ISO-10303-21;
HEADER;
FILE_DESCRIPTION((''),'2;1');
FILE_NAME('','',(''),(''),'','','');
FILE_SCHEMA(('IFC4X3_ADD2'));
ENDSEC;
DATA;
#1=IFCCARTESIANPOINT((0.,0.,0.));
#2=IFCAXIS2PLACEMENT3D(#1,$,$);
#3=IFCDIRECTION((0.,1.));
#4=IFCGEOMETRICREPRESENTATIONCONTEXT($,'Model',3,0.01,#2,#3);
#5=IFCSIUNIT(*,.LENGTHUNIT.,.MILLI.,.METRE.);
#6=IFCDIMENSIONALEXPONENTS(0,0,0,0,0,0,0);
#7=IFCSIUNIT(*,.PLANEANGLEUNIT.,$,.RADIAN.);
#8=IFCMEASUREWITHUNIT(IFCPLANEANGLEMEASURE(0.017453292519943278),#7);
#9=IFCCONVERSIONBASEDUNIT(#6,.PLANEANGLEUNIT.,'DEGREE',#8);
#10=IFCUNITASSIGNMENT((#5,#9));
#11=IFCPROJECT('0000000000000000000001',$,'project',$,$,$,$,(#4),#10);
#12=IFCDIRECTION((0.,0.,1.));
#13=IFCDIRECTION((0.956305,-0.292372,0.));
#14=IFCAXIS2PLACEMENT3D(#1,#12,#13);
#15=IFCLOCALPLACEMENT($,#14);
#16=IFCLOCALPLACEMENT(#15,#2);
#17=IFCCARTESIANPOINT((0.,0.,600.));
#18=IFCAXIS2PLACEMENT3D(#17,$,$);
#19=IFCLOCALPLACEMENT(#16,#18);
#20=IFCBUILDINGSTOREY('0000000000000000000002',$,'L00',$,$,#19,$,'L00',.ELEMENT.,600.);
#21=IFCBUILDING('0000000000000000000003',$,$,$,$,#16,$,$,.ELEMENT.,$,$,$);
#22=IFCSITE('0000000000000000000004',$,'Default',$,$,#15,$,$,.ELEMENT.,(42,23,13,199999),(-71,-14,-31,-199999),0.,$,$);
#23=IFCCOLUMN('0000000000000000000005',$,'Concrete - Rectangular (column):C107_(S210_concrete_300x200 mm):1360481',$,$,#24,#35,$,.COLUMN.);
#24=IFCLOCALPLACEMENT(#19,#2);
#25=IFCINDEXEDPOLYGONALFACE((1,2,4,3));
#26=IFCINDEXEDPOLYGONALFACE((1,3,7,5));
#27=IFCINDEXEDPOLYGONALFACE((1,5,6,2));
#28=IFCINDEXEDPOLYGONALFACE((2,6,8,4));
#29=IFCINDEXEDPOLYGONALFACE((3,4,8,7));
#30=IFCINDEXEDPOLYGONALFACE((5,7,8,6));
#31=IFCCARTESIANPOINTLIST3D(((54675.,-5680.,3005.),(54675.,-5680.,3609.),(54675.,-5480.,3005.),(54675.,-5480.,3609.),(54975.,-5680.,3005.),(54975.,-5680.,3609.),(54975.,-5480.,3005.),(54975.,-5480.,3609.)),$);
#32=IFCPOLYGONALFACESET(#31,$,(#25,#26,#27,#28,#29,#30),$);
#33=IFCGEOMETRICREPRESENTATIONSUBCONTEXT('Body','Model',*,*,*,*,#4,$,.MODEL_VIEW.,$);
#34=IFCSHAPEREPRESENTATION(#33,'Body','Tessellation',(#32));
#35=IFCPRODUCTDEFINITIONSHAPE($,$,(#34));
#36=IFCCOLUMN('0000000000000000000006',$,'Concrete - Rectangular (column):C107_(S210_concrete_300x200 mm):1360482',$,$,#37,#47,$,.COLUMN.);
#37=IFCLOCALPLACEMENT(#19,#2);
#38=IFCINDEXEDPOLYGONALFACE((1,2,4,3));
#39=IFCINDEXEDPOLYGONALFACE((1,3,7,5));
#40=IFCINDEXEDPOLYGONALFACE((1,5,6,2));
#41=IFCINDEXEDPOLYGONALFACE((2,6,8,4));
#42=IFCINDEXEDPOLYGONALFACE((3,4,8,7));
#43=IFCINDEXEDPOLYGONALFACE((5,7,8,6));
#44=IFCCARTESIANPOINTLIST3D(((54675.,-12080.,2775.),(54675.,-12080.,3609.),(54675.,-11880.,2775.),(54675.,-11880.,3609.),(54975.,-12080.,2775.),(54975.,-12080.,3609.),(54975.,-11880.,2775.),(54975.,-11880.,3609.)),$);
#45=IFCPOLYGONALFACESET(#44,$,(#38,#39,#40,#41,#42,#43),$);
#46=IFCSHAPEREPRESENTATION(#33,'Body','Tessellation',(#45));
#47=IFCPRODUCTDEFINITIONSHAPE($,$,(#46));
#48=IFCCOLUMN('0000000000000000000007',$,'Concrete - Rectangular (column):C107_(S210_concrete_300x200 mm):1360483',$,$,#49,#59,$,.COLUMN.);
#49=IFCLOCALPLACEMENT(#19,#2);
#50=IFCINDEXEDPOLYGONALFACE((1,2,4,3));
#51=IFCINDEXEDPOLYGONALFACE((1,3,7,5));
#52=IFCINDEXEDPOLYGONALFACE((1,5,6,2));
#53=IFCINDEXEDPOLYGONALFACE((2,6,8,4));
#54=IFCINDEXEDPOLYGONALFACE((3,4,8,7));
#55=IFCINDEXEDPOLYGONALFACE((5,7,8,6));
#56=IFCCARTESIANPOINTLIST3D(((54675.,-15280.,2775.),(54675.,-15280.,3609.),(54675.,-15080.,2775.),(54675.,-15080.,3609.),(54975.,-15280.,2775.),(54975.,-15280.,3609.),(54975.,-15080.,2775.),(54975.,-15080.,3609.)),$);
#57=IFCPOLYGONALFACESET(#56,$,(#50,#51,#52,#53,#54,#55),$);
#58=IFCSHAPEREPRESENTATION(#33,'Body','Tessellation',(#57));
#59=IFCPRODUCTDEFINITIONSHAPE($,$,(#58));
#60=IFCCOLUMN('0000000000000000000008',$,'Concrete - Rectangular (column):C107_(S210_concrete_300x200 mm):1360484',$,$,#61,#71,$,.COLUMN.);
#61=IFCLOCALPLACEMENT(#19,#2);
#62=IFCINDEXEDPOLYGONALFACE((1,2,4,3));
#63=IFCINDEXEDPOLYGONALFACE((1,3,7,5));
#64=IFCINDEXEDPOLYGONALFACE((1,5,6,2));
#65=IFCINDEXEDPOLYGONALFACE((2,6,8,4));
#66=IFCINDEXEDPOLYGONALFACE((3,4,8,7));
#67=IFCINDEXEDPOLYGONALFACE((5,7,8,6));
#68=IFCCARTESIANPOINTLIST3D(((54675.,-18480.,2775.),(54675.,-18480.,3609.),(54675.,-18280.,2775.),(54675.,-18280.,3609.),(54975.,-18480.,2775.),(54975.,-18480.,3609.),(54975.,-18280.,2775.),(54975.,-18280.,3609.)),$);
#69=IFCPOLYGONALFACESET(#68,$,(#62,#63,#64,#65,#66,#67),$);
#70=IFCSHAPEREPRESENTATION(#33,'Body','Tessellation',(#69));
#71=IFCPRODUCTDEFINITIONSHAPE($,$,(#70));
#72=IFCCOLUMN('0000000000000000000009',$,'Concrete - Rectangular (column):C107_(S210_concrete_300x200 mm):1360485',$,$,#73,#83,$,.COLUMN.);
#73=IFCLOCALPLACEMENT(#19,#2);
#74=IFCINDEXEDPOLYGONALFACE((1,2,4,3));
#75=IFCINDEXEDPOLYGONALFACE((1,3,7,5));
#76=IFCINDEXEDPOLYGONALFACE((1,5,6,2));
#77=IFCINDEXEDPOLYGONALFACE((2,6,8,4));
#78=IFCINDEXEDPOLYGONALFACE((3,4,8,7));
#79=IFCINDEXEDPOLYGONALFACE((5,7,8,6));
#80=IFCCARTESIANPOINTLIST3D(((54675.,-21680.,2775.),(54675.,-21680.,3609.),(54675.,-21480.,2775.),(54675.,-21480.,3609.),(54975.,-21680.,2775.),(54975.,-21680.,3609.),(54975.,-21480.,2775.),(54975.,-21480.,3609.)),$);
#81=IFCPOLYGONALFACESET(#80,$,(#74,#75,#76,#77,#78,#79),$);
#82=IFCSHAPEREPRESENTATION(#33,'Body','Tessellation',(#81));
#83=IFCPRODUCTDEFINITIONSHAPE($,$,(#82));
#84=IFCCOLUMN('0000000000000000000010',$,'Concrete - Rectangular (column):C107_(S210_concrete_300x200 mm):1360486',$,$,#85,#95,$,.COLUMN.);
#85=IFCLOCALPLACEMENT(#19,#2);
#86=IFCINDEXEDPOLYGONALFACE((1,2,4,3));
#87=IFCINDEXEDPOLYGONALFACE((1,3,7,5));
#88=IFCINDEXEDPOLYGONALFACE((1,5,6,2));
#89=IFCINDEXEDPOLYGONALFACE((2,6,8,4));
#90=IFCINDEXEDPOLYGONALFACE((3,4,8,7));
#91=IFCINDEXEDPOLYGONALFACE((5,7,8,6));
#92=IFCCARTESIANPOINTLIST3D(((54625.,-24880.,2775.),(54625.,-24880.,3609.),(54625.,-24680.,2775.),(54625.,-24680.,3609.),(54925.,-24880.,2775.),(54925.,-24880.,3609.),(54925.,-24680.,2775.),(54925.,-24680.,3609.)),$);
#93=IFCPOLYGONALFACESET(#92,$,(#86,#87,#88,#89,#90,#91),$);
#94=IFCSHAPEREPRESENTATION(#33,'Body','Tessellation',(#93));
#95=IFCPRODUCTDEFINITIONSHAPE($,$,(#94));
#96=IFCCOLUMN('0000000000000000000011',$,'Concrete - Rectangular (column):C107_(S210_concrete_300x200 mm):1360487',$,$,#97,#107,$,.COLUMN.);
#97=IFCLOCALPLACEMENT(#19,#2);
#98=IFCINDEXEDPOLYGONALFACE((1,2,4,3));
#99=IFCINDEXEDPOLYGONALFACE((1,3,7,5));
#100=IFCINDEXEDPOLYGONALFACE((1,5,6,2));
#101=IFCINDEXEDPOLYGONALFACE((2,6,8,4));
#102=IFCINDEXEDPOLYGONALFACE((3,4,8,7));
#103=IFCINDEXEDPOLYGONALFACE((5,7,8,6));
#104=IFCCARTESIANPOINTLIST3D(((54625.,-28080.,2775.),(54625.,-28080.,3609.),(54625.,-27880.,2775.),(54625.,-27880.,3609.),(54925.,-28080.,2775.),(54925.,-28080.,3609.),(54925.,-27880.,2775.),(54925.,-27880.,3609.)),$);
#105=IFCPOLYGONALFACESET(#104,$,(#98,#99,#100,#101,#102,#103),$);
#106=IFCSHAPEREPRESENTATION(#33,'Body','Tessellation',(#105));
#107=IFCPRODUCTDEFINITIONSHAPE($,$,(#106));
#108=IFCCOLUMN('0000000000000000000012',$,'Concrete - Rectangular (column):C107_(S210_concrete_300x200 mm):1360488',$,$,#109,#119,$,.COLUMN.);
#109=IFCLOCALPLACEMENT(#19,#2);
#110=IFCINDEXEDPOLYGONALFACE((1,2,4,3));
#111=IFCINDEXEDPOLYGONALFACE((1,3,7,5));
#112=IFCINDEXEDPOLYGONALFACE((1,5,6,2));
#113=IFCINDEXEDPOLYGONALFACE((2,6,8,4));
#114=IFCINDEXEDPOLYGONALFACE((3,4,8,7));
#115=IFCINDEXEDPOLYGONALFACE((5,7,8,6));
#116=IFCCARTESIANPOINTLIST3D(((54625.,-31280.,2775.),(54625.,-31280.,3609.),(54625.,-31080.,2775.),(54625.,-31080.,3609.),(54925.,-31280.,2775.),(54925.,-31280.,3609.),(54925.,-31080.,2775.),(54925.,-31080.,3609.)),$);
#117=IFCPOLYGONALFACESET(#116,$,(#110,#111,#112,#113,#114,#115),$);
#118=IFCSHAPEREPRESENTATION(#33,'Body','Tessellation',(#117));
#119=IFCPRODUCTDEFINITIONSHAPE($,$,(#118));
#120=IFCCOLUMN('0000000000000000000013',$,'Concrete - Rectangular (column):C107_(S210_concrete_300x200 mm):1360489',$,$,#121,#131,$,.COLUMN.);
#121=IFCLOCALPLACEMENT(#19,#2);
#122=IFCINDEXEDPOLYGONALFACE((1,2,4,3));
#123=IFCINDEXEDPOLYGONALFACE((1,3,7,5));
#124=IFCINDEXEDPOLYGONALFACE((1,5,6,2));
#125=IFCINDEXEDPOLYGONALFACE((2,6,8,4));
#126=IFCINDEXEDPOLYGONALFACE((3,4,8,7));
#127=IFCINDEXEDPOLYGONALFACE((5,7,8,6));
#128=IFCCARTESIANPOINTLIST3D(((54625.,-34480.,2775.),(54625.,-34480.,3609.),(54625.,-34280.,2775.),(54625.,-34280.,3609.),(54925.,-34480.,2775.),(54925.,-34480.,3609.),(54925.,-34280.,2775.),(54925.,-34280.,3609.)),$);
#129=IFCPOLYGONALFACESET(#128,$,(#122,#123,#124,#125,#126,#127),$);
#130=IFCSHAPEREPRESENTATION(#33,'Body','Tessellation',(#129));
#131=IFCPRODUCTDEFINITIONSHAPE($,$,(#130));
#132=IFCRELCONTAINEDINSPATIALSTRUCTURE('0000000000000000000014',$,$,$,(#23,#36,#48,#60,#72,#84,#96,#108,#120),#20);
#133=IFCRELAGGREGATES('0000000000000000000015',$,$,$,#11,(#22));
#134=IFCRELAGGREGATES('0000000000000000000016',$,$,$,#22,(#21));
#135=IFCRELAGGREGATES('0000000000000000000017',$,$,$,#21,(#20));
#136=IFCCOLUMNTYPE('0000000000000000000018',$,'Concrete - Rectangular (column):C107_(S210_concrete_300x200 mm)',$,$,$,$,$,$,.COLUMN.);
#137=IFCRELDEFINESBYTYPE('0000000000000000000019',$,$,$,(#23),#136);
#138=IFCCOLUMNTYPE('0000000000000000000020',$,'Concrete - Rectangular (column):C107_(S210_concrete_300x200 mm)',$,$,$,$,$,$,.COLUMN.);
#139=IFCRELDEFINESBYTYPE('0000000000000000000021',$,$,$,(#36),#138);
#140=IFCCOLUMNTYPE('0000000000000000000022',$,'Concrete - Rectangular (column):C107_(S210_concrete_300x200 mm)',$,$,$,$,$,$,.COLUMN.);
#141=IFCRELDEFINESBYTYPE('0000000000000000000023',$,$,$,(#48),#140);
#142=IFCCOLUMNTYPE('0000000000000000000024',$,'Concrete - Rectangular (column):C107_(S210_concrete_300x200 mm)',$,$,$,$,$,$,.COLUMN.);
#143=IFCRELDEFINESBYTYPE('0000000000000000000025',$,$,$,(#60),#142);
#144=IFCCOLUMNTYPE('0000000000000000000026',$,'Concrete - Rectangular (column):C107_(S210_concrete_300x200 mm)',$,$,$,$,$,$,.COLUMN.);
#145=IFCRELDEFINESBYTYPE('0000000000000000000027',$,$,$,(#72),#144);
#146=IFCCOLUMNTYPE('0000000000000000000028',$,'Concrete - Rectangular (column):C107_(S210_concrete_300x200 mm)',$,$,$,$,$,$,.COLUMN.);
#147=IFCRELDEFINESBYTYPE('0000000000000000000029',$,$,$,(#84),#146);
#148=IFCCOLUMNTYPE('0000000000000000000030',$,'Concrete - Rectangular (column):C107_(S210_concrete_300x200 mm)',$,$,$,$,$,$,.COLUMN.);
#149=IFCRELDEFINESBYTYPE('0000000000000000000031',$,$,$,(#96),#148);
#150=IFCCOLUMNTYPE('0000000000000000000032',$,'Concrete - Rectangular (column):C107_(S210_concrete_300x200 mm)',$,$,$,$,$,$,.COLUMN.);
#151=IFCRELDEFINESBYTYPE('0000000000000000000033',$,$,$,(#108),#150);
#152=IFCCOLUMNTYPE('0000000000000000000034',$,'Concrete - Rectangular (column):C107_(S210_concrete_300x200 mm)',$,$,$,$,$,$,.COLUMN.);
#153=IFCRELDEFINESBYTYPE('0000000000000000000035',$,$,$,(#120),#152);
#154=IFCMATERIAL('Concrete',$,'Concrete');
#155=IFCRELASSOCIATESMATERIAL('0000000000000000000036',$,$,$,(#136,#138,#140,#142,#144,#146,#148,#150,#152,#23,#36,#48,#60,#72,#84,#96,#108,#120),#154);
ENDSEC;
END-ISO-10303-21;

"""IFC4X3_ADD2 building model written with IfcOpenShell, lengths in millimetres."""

from ifc_helpers import new_model, entity, si_unit, converted_unit, direction, frame, frame_2d, origin, origin_2d_with_axis, place, context, subcontext, project, spatial, rectangle, extrude, source, transform, mapped, material, material_profile, profile_set, profile_usage, type_object, type_shapes, element, save


model = new_model("IFC4X3_ADD2")

# Units and contexts
model_context = context("Model", 3, precision=0.01, world=origin(), true_north=direction((0.0, 1.0)))
body_context = subcontext(model_context, "Body", "Model", "MODEL_VIEW")
ifc_project = project(units=[si_unit("LENGTHUNIT", "METRE", prefix="MILLI"), converted_unit("PLANEANGLEUNIT", "DEGREE", entity("IfcPlaneAngleMeasure", 0.017453292519943278), si_unit("PLANEANGLEUNIT", "RADIAN"), dimensions=[0, 0, 0, 0, 0, 0, 0])], contexts=[model_context])

# Site, building, storey
site_placement = place(None, frame((0.0, 0.0, 0.0), z_axis=(0.0, 0.0, 1.0), x_axis=(0.956305, -0.292372, 0.0)))
site = spatial("IfcSite", under=ifc_project, at=site_placement, Name="Default", CompositionType="ELEMENT", RefLatitude=(42, 23, 13, 199999), RefLongitude=(-71, -14, -31, -199999), RefElevation=0.0)
building_placement = place(site_placement, origin())
building = spatial("IfcBuilding", under=site, at=building_placement, CompositionType="ELEMENT")
storey_placement = place(building_placement, frame((0.0, 0.0, 600.0)))
storey = spatial("IfcBuildingStorey", under=building, at=storey_placement, Name="L00", LongName="L00", CompositionType="ELEMENT", Elevation=600.0)

# Columns
ifc_material = material(Name="Concrete", Category="Concrete")
ifc_material_profile = material_profile(ifc_material, rectangle(XDim=300.0, YDim=200.0, at=frame_2d((0.0, 0.0), x_axis=(1.0, 0.0))), Name="C107_(S210_concrete_300x200 mm)")
ifc_profile_set = profile_set([ifc_material_profile], Name="C107_(S210_concrete_300x200 mm)")
ifc_profile_usage = profile_usage(ifc_profile_set)
column_type_1 = type_object("IfcColumnType", Name="Concrete - Rectangular (column):C107_(S210_concrete_300x200 mm)", PredefinedType="COLUMN", material=ifc_profile_set)
shared_shape_1 = source(origin(), body_context, "Body", "SweptSolid", [
    extrude(rectangle(XDim=200.0, YDim=300.0, at=frame_2d((0.0, 0.0), x_axis=(1.0, 0.0))), frame((54825.0, -5580.0, 3605.0), z_axis=(0.0, 0.0, 1.0), x_axis=(0.0, 1.0, 0.0)), (0.0, 0.0, 1.0), 604.0),
])
type_shapes(column_type_1, [shared_shape_1])
column_1_placement = place(storey_placement, frame((0.0, 0.0, -600.0)))
element("IfcColumn", 1, at=column_1_placement, inside=storey, type_object=column_type_1, material=ifc_profile_usage, Name="Concrete - Rectangular (column):C107_(S210_concrete_300x200 mm):1360481", PredefinedType="COLUMN", context=body_context, shape_type="MappedRepresentation", body=[
    mapped(shared_shape_1, transform((0.0, 0.0, 0.0), scale=1.0)),
])
column_type_2 = type_object("IfcColumnType", Name="Concrete - Rectangular (column):C107_(S210_concrete_300x200 mm)", PredefinedType="COLUMN", material=ifc_profile_set)
shared_shape_2 = source(origin(), body_context, "Body", "SweptSolid", [
    extrude(rectangle(XDim=200.0, YDim=300.0, at=frame_2d((0.0, 0.0), x_axis=(1.0, 0.0))), frame((54825.0, -11980.0, 3375.0), z_axis=(0.0, 0.0, 1.0), x_axis=(0.0, 1.0, 0.0)), (0.0, 0.0, 1.0), 834.0),
])
type_shapes(column_type_2, [shared_shape_2])
column_2_placement = place(storey_placement, frame((0.0, 0.0, -600.0)))
element("IfcColumn", 2, at=column_2_placement, inside=storey, type_object=column_type_2, material=ifc_profile_usage, Name="Concrete - Rectangular (column):C107_(S210_concrete_300x200 mm):1360482", PredefinedType="COLUMN", context=body_context, shape_type="MappedRepresentation", body=[
    mapped(shared_shape_2, transform((0.0, 0.0, 0.0), scale=1.0)),
])
column_type_3 = type_object("IfcColumnType", Name="Concrete - Rectangular (column):C107_(S210_concrete_300x200 mm)", PredefinedType="COLUMN", material=ifc_profile_set)
shared_shape_3 = source(origin(), body_context, "Body", "SweptSolid", [
    extrude(rectangle(XDim=200.0, YDim=300.0, at=frame_2d((0.0, 0.0), x_axis=(1.0, 0.0))), frame((54825.0, -15180.0, 3375.0), z_axis=(0.0, 0.0, 1.0), x_axis=(0.0, 1.0, 0.0)), (0.0, 0.0, 1.0), 834.0),
])
type_shapes(column_type_3, [shared_shape_3])
column_3_placement = place(storey_placement, frame((0.0, 0.0, -600.0)))
element("IfcColumn", 3, at=column_3_placement, inside=storey, type_object=column_type_3, material=ifc_profile_usage, Name="Concrete - Rectangular (column):C107_(S210_concrete_300x200 mm):1360483", PredefinedType="COLUMN", context=body_context, shape_type="MappedRepresentation", body=[
    mapped(shared_shape_3, transform((0.0, 0.0, 0.0), scale=1.0)),
])
column_type_4 = type_object("IfcColumnType", Name="Concrete - Rectangular (column):C107_(S210_concrete_300x200 mm)", PredefinedType="COLUMN", material=ifc_profile_set)
shared_shape_4 = source(origin(), body_context, "Body", "SweptSolid", [
    extrude(rectangle(XDim=200.0, YDim=300.0, at=frame_2d((0.0, 0.0), x_axis=(1.0, 0.0))), frame((54825.0, -18380.0, 3375.0), z_axis=(0.0, 0.0, 1.0), x_axis=(0.0, 1.0, 0.0)), (0.0, 0.0, 1.0), 834.0),
])
type_shapes(column_type_4, [shared_shape_4])
column_4_placement = place(storey_placement, frame((0.0, 0.0, -600.0)))
element("IfcColumn", 4, at=column_4_placement, inside=storey, type_object=column_type_4, material=ifc_profile_usage, Name="Concrete - Rectangular (column):C107_(S210_concrete_300x200 mm):1360484", PredefinedType="COLUMN", context=body_context, shape_type="MappedRepresentation", body=[
    mapped(shared_shape_4, transform((0.0, 0.0, 0.0), scale=1.0)),
])
column_type_5 = type_object("IfcColumnType", Name="Concrete - Rectangular (column):C107_(S210_concrete_300x200 mm)", PredefinedType="COLUMN", material=ifc_profile_set)
shared_shape_5 = source(origin(), body_context, "Body", "SweptSolid", [
    extrude(rectangle(XDim=200.0, YDim=300.0, at=origin_2d_with_axis()), frame((54825.0, -21580.0, 3375.0), z_axis=(0.0, 0.0, 1.0), x_axis=(0.0, 1.0, 0.0)), (0.0, 0.0, 1.0), 834.0),
])
type_shapes(column_type_5, [shared_shape_5])
column_5_placement = place(storey_placement, frame((0.0, 0.0, -600.0)))
element("IfcColumn", 5, at=column_5_placement, inside=storey, type_object=column_type_5, material=ifc_profile_usage, Name="Concrete - Rectangular (column):C107_(S210_concrete_300x200 mm):1360485", PredefinedType="COLUMN", context=body_context, shape_type="MappedRepresentation", body=[
    mapped(shared_shape_5, transform((0.0, 0.0, 0.0), scale=1.0)),
])
column_type_6 = type_object("IfcColumnType", Name="Concrete - Rectangular (column):C107_(S210_concrete_300x200 mm)", PredefinedType="COLUMN", material=ifc_profile_set)
shared_shape_6 = source(origin(), body_context, "Body", "SweptSolid", [
    extrude(rectangle(XDim=200.0, YDim=300.0, at=origin_2d_with_axis()), frame((54775.0, -24780.0, 3375.0), z_axis=(0.0, 0.0, 1.0), x_axis=(0.0, 1.0, 0.0)), (0.0, 0.0, 1.0), 834.0),
])
type_shapes(column_type_6, [shared_shape_6])
column_6_placement = place(storey_placement, frame((0.0, 0.0, -600.0)))
element("IfcColumn", 6, at=column_6_placement, inside=storey, type_object=column_type_6, material=ifc_profile_usage, Name="Concrete - Rectangular (column):C107_(S210_concrete_300x200 mm):1360486", PredefinedType="COLUMN", context=body_context, shape_type="MappedRepresentation", body=[
    mapped(shared_shape_6, transform((0.0, 0.0, 0.0), scale=1.0)),
])
column_type_7 = type_object("IfcColumnType", Name="Concrete - Rectangular (column):C107_(S210_concrete_300x200 mm)", PredefinedType="COLUMN", material=ifc_profile_set)
shared_shape_7 = source(origin(), body_context, "Body", "SweptSolid", [
    extrude(rectangle(XDim=200.0, YDim=300.0, at=frame_2d((0.0, 0.0), x_axis=(1.0, 0.0))), frame((54775.0, -27980.0, 3375.0), z_axis=(0.0, 0.0, 1.0), x_axis=(0.0, 1.0, 0.0)), (0.0, 0.0, 1.0), 834.0),
])
type_shapes(column_type_7, [shared_shape_7])
column_7_placement = place(storey_placement, frame((0.0, 0.0, -600.0)))
element("IfcColumn", 7, at=column_7_placement, inside=storey, type_object=column_type_7, material=ifc_profile_usage, Name="Concrete - Rectangular (column):C107_(S210_concrete_300x200 mm):1360487", PredefinedType="COLUMN", context=body_context, shape_type="MappedRepresentation", body=[
    mapped(shared_shape_7, transform((0.0, 0.0, 0.0), scale=1.0)),
])
column_type_8 = type_object("IfcColumnType", Name="Concrete - Rectangular (column):C107_(S210_concrete_300x200 mm)", PredefinedType="COLUMN", material=ifc_profile_set)
shared_shape_8 = source(origin(), body_context, "Body", "SweptSolid", [
    extrude(rectangle(XDim=200.0, YDim=300.0, at=frame_2d((0.0, 0.0), x_axis=(1.0, 0.0))), frame((54775.0, -31180.0, 3375.0), z_axis=(0.0, 0.0, 1.0), x_axis=(0.0, 1.0, 0.0)), (0.0, 0.0, 1.0), 834.0),
])
type_shapes(column_type_8, [shared_shape_8])
column_8_placement = place(storey_placement, frame((0.0, 0.0, -600.0)))
element("IfcColumn", 8, at=column_8_placement, inside=storey, type_object=column_type_8, material=ifc_profile_usage, Name="Concrete - Rectangular (column):C107_(S210_concrete_300x200 mm):1360488", PredefinedType="COLUMN", context=body_context, shape_type="MappedRepresentation", body=[
    mapped(shared_shape_8, transform((0.0, 0.0, 0.0), scale=1.0)),
])
column_type_9 = type_object("IfcColumnType", Name="Concrete - Rectangular (column):C107_(S210_concrete_300x200 mm)", PredefinedType="COLUMN", material=ifc_profile_set)
shared_shape_9 = source(origin(), body_context, "Body", "SweptSolid", [
    extrude(rectangle(XDim=200.0, YDim=300.0, at=frame_2d((0.0, 0.0), x_axis=(1.0, 0.0))), frame((54775.0, -34380.0, 3375.0), z_axis=(0.0, 0.0, 1.0), x_axis=(0.0, 1.0, 0.0)), (0.0, 0.0, 1.0), 834.0),
])
type_shapes(column_type_9, [shared_shape_9])
column_9_placement = place(storey_placement, frame((0.0, 0.0, -600.0)))
element("IfcColumn", 9, at=column_9_placement, inside=storey, type_object=column_type_9, material=ifc_profile_usage, Name="Concrete - Rectangular (column):C107_(S210_concrete_300x200 mm):1360489", PredefinedType="COLUMN", context=body_context, shape_type="MappedRepresentation", body=[
    mapped(shared_shape_9, transform((0.0, 0.0, 0.0), scale=1.0)),
])

save(model, "model.ifc")
